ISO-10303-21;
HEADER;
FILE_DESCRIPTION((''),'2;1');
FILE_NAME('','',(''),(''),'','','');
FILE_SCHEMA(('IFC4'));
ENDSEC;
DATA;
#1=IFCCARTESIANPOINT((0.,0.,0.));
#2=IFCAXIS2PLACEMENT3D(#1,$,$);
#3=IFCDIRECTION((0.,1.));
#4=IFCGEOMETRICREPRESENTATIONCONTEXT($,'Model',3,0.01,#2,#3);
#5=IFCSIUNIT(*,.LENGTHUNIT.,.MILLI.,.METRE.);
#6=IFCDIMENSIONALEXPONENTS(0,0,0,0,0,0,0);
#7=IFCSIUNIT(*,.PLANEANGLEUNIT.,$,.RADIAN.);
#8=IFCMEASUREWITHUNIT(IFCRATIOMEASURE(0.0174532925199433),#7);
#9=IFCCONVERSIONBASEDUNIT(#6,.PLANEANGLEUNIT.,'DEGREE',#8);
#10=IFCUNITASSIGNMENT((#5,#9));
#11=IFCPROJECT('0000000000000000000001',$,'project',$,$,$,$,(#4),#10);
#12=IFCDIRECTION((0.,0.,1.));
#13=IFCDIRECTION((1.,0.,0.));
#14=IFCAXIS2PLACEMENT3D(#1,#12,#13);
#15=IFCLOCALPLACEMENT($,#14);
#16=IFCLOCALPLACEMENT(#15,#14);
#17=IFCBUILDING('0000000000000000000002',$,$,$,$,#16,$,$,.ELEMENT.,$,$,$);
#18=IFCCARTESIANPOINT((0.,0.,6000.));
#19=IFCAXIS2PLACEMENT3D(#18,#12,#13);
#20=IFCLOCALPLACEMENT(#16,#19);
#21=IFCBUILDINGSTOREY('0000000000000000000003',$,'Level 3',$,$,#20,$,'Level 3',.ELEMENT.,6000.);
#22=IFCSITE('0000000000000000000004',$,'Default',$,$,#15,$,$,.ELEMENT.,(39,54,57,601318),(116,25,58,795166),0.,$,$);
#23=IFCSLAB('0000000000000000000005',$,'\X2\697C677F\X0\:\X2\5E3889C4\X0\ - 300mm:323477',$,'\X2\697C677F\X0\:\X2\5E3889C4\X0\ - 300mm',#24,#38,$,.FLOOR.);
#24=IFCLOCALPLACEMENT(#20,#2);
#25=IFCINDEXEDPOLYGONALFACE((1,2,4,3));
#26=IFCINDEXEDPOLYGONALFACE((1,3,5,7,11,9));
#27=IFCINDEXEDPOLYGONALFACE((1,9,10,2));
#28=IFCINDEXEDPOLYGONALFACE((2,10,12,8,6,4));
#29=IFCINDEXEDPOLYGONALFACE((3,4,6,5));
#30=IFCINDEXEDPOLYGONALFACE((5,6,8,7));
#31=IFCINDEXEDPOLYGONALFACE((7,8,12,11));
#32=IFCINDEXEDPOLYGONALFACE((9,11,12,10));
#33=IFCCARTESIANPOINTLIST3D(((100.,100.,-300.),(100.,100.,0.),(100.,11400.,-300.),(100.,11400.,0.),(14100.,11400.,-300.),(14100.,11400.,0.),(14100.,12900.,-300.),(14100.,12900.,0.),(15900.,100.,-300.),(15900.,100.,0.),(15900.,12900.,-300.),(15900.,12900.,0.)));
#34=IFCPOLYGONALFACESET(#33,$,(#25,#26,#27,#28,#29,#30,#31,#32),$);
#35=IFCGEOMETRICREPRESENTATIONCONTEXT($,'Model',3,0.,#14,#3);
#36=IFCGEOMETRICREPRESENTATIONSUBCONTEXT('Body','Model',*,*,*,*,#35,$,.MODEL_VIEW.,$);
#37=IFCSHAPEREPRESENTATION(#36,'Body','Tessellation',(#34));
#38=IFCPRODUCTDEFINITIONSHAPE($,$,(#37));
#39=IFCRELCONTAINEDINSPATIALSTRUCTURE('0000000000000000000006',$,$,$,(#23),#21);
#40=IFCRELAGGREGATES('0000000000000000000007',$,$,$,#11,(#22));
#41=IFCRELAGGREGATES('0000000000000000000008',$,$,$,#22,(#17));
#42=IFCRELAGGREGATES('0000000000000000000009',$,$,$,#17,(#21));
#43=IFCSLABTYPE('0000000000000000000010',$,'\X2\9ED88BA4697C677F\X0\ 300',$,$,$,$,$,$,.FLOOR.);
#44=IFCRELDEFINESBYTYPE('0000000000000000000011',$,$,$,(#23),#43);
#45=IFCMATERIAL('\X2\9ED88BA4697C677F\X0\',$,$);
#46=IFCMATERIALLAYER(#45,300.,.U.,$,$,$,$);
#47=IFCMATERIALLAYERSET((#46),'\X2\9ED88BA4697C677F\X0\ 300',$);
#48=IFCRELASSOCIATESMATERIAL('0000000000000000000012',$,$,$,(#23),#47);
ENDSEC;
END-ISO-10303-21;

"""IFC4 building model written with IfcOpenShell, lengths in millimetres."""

from ifc_helpers import new_model, entity, si_unit, converted_unit, direction, frame, origin, origin_with_axes, place, context, subcontext, project, spatial, polyline, outline, extrude, material, layer, layer_set, layer_usage, type_object, element, save


model = new_model("IFC4")

# Units and contexts
model_context_1 = context("Model", 3, precision=0.01, world=origin(), true_north=direction((0.0, 1.0)))
model_context_2 = context("Model", 3, precision=0.0, world=origin_with_axes(), true_north=direction((0.0, 1.0)))
body_context = subcontext(model_context_2, "Body", "Model", "MODEL_VIEW")
ifc_project = project(units=[si_unit("LENGTHUNIT", "METRE", prefix="MILLI"), converted_unit("PLANEANGLEUNIT", "DEGREE", entity("IfcRatioMeasure", 0.0174532925199433), si_unit("PLANEANGLEUNIT", "RADIAN"), dimensions=[0, 0, 0, 0, 0, 0, 0])], contexts=[model_context_1])

# Site, building, storey
site_placement = place(None, origin_with_axes())
site = spatial("IfcSite", under=ifc_project, at=site_placement, Name="Default", CompositionType="ELEMENT", RefLatitude=(39, 54, 57, 601318), RefLongitude=(116, 25, 58, 795166), RefElevation=0.0)
building_placement = place(site_placement, origin_with_axes())
building = spatial("IfcBuilding", under=site, at=building_placement, CompositionType="ELEMENT")
storey_placement = place(building_placement, frame((0.0, 0.0, 6000.0), z_axis=(0.0, 0.0, 1.0), x_axis=(1.0, 0.0, 0.0)))
storey = spatial("IfcBuildingStorey", under=building, at=storey_placement, Name="Level 3", LongName="Level 3", CompositionType="ELEMENT", Elevation=6000.0)

# Slab
ifc_material = material(Name="默认楼板")
ifc_layer = layer(ifc_material, 300.0, ventilated="UNKNOWN")
ifc_layer_set = layer_set([ifc_layer], Name="默认楼板 300")
ifc_layer_usage = layer_usage(ifc_layer_set, "AXIS3", "NEGATIVE", 300.0)
slab_type = type_object("IfcSlabType", Name="默认楼板 300", PredefinedType="FLOOR")
slab_placement = place(storey_placement, frame((100.0, 100.0, 0.0), z_axis=(0.0, 0.0, 1.0), x_axis=(1.0, 0.0, 0.0)))
element("IfcSlab", 1, at=slab_placement, inside=storey, type_object=slab_type, material=ifc_layer_usage, Name="楼板:常规 - 300mm:323477", ObjectType="楼板:常规 - 300mm", PredefinedType="FLOOR", context=body_context, shape_type="SweptSolid", body=[
    extrude(outline(polyline([(0.0, 0.0), (15800.0, 0.0), (15800.0, 12800.0), (14000.0, 12800.0), (14000.0, 11300.0), (0.0, 11300.0), (0.0, 0.0)])), frame((0.0, 0.0, -300.0), z_axis=(0.0, 0.0, 1.0), x_axis=(1.0, 0.0, 0.0)), (0.0, 0.0, 1.0), 300.0),
])

save(model, "model.ifc")
